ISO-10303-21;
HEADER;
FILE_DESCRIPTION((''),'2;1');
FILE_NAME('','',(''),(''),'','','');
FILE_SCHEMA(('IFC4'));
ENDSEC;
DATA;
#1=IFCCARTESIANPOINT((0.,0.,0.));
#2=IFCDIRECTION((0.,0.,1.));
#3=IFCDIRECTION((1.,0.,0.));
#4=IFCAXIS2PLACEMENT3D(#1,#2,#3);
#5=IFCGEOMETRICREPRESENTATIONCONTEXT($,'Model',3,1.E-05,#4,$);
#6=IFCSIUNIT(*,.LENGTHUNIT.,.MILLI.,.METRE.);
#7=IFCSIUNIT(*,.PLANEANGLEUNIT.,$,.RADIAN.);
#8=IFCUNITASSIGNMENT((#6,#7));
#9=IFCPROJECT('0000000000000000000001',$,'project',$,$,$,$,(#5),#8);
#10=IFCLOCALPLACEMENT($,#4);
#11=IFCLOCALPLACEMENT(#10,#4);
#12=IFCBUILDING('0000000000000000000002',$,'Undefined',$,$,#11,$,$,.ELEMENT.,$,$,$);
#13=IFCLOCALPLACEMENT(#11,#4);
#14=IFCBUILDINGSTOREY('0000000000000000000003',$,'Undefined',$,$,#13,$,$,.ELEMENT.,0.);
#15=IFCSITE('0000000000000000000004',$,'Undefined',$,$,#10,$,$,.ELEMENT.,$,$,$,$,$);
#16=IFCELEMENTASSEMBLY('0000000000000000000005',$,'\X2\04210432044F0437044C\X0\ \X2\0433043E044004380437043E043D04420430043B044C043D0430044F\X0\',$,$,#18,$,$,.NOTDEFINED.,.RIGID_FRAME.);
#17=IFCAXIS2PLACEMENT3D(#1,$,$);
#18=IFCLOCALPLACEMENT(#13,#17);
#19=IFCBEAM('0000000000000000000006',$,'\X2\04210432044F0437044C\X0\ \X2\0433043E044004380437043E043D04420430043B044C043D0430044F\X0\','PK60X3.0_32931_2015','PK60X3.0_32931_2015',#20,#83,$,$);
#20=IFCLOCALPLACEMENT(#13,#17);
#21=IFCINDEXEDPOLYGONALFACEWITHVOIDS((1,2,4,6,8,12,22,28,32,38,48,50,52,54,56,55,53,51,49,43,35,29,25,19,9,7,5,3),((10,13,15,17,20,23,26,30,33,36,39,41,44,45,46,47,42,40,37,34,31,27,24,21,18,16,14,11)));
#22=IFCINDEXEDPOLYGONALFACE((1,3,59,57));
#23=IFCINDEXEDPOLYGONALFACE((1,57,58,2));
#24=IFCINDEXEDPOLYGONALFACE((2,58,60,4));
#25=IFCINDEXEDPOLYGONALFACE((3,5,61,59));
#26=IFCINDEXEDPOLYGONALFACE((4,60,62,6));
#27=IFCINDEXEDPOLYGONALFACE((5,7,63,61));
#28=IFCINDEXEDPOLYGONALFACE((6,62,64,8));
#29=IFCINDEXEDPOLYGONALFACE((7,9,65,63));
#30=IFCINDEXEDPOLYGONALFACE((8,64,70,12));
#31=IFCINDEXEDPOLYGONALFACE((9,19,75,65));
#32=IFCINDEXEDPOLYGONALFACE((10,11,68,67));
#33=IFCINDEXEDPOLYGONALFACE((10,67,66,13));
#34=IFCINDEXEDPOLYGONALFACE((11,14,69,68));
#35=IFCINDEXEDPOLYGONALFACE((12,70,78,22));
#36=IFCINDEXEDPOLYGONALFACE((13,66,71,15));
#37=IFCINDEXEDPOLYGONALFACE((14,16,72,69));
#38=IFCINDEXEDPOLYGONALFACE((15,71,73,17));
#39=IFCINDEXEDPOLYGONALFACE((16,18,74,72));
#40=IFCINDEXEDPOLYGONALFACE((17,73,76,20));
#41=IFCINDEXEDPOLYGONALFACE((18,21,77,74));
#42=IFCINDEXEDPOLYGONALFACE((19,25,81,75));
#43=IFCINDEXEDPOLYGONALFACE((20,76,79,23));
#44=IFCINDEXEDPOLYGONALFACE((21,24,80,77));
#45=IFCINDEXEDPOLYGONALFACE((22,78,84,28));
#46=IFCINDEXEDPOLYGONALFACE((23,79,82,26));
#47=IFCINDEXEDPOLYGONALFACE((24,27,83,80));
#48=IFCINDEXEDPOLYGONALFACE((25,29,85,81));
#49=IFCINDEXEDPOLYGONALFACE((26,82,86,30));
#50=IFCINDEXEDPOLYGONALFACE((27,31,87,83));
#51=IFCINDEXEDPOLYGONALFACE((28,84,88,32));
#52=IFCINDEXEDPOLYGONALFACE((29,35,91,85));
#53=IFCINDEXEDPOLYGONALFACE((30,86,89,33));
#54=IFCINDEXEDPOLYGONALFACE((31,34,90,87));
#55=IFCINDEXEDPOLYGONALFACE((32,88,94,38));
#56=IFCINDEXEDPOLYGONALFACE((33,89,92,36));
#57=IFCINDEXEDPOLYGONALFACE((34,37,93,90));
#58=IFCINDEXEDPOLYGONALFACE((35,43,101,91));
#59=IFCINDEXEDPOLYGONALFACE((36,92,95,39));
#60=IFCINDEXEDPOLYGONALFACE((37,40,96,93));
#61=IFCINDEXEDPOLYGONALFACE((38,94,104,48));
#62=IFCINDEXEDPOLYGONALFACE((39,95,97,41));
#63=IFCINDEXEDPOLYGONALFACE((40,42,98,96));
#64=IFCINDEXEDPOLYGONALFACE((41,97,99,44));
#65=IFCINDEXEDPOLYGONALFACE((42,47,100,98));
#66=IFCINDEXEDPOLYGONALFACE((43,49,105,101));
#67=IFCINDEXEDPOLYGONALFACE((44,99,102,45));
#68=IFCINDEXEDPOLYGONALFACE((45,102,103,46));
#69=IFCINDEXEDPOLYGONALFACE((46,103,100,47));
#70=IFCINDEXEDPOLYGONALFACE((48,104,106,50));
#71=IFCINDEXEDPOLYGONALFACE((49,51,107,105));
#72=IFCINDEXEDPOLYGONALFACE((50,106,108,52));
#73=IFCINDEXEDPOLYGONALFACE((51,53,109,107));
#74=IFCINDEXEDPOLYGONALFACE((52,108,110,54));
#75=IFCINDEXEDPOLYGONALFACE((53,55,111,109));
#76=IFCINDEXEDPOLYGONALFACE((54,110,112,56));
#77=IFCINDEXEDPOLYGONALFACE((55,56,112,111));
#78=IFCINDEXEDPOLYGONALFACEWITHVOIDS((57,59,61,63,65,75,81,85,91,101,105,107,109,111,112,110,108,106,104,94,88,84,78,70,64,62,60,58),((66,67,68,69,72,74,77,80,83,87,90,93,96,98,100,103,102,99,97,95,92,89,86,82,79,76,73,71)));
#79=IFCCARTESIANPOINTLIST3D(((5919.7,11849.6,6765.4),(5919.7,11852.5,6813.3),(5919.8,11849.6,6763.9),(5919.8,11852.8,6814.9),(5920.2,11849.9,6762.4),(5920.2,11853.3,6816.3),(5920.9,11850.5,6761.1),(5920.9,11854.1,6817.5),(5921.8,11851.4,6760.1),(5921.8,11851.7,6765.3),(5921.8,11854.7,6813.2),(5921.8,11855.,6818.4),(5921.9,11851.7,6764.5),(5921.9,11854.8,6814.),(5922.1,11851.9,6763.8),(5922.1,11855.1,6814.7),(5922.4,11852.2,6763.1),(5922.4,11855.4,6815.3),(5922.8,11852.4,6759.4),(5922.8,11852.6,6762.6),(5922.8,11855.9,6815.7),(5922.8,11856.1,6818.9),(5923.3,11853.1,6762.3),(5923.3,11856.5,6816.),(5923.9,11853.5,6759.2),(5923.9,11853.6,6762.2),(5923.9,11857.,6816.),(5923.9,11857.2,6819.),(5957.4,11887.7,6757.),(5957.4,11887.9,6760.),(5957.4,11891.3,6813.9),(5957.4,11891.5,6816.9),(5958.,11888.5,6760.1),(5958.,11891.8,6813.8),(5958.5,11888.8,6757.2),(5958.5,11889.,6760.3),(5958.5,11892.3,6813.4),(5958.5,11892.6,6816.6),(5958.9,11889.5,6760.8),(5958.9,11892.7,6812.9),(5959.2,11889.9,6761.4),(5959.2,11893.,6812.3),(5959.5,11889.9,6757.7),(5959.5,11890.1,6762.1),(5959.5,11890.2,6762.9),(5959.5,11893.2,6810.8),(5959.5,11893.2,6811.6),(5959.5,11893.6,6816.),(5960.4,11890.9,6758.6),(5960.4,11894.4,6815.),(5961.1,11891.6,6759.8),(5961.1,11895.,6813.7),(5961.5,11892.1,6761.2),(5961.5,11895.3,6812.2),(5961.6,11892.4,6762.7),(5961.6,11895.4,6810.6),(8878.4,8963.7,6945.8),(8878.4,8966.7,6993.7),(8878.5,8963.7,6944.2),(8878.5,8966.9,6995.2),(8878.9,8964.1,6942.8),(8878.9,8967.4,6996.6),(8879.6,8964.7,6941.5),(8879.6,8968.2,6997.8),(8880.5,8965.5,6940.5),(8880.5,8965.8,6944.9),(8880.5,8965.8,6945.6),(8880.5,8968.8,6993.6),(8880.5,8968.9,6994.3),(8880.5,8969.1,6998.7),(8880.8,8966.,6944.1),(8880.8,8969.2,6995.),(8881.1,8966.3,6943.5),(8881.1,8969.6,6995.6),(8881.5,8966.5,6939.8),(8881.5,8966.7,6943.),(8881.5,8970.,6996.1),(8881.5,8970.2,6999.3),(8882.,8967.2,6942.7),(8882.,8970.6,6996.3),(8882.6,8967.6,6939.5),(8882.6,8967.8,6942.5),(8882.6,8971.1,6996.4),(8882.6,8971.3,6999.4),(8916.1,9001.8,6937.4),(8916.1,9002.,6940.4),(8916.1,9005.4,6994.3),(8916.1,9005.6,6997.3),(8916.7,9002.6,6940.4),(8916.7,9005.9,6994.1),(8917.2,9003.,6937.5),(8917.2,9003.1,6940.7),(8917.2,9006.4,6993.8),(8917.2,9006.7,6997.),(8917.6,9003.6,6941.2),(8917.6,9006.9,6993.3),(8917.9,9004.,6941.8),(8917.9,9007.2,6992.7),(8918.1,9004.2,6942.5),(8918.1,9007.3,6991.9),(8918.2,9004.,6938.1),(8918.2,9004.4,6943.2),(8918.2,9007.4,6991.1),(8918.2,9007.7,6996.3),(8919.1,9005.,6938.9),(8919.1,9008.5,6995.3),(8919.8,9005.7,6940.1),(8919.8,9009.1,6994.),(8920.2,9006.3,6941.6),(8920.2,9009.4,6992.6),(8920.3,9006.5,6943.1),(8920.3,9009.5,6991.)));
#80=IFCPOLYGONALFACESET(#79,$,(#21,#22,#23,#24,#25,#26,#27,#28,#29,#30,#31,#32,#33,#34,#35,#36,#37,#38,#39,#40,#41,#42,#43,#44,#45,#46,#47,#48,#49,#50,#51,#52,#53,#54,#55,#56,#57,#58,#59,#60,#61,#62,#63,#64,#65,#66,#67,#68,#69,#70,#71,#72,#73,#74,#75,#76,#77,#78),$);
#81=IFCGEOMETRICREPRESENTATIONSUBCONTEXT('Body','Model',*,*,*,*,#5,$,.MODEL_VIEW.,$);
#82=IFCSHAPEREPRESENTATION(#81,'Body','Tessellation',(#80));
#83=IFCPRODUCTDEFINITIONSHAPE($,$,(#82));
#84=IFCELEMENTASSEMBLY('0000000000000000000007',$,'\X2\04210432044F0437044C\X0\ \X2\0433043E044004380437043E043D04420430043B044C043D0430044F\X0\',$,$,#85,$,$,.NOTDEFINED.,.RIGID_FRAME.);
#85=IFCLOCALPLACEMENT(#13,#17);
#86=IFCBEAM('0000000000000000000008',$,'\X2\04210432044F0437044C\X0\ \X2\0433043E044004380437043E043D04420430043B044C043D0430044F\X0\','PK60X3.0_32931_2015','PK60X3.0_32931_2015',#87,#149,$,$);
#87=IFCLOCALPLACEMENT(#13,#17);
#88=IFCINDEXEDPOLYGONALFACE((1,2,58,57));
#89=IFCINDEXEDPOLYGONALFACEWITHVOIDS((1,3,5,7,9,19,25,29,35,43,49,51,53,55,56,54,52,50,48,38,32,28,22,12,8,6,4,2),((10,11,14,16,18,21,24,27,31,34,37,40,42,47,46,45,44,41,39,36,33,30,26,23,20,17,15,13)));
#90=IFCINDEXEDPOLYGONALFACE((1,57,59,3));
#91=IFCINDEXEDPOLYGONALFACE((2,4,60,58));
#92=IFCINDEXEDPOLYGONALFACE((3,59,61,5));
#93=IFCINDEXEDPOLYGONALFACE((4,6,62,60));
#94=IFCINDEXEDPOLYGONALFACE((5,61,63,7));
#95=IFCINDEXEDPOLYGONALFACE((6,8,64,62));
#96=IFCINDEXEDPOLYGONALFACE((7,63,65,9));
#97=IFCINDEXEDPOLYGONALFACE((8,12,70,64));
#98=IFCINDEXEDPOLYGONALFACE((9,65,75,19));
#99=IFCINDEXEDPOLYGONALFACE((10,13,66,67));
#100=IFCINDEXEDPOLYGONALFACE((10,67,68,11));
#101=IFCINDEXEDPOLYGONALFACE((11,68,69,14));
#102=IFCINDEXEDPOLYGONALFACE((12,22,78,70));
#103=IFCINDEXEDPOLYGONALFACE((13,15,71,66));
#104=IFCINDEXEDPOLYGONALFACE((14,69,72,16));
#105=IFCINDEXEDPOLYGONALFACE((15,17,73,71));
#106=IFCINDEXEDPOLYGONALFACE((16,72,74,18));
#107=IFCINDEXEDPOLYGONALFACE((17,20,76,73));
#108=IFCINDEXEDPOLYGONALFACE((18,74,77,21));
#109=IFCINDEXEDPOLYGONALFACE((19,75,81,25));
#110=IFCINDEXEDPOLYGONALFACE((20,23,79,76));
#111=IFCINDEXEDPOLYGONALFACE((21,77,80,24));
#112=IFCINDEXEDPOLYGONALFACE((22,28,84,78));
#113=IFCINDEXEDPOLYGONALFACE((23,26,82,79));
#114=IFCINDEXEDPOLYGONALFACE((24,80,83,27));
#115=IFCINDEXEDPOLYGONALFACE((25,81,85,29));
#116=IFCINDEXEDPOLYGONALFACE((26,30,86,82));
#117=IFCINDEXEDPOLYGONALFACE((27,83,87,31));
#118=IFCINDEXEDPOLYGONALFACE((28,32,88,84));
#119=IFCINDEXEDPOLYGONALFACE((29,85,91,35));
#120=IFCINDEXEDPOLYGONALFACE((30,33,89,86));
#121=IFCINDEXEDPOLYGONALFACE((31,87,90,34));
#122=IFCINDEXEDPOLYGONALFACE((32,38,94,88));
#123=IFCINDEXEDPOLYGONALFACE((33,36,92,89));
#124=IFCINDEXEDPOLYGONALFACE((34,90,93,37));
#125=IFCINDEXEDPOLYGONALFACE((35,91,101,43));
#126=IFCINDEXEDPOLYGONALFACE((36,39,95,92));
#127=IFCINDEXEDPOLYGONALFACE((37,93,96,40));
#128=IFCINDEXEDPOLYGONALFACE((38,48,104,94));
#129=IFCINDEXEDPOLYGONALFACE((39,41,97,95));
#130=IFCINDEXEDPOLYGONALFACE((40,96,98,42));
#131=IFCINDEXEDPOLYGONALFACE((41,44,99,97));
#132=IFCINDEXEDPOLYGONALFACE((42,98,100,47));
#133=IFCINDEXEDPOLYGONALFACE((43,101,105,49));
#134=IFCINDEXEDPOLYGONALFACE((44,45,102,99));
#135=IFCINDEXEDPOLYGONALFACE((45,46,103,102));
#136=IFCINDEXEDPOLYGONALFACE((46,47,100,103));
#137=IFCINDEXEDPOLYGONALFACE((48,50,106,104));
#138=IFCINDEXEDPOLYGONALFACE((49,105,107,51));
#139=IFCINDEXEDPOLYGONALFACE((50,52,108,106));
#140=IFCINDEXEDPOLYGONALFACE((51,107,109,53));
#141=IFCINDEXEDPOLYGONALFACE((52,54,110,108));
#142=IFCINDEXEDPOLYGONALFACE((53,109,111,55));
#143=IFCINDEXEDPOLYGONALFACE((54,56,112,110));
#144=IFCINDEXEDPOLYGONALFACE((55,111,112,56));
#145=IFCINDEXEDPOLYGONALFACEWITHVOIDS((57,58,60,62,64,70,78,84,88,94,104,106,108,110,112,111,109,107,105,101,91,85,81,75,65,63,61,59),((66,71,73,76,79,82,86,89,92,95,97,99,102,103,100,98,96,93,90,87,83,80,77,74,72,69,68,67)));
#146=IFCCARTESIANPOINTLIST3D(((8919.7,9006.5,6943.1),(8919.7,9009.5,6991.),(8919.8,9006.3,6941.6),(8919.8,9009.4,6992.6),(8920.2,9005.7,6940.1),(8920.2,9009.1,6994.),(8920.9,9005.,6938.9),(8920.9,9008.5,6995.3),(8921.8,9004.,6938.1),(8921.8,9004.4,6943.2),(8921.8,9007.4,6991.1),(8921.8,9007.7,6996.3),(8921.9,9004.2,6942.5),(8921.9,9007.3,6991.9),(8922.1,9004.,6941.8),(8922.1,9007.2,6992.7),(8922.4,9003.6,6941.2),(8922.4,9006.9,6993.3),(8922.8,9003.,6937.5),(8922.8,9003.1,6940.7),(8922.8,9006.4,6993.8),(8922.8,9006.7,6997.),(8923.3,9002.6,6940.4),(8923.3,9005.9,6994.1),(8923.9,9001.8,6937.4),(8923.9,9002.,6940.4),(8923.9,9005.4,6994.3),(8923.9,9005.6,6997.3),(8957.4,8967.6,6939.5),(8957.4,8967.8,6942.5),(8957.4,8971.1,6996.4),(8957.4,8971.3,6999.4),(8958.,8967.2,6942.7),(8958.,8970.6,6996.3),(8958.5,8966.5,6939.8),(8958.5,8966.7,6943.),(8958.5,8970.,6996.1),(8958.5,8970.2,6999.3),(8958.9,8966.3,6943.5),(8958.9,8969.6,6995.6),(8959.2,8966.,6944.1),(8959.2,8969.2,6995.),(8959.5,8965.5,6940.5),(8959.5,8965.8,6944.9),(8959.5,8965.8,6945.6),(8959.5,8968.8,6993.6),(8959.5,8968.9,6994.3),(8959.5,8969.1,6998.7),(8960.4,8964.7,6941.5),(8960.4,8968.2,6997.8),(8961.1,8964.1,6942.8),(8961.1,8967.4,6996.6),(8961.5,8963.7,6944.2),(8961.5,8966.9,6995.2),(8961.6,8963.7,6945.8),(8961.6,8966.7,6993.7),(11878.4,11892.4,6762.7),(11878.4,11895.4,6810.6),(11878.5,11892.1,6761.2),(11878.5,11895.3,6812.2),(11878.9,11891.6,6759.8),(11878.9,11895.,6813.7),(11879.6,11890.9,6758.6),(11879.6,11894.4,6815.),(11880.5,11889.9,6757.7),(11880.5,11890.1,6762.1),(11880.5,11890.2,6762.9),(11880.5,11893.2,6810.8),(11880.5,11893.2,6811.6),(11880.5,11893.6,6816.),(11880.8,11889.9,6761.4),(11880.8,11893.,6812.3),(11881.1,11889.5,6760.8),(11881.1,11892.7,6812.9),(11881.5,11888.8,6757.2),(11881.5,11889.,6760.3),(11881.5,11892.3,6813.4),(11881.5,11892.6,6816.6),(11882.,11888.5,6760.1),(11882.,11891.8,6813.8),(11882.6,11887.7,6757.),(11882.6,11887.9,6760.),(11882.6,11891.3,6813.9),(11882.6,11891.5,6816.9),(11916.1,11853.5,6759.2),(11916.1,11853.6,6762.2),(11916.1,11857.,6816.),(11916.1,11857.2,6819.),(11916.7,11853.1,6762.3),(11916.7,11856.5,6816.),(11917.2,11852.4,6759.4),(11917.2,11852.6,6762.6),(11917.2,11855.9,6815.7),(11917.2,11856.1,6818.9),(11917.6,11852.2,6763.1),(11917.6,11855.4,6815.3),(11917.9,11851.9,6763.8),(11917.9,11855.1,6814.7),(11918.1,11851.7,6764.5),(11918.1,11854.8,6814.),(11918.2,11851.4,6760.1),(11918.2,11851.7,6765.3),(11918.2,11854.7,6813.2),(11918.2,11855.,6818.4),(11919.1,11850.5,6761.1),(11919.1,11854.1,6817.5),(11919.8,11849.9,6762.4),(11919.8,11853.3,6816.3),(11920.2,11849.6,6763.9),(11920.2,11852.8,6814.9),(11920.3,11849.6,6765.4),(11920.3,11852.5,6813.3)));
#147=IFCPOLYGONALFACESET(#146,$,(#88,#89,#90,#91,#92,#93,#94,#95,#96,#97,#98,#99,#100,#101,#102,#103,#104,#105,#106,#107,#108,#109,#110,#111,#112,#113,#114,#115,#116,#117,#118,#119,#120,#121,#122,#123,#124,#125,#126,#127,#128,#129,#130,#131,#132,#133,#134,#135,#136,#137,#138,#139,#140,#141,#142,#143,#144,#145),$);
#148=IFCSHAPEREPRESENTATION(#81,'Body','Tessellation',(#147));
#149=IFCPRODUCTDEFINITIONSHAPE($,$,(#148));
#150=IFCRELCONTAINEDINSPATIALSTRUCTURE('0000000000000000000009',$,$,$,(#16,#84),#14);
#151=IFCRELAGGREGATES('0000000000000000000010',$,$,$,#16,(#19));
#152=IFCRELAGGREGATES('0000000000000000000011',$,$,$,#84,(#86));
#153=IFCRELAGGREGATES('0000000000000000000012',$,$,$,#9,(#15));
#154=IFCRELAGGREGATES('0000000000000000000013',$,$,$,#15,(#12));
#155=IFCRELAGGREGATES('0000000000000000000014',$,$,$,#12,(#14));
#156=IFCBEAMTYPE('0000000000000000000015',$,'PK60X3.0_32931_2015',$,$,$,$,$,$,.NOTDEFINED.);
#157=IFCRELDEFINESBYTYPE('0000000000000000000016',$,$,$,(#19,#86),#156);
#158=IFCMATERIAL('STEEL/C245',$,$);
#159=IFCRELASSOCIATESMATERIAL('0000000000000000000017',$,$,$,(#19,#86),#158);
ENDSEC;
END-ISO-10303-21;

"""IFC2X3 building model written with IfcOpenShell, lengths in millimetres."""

from ifc_helpers import new_model, si_unit, frame, origin_with_axes, origin_2d_with_axis, place, context, subcontext, project, spatial, hollow_rectangle, extrude, material, type_object, element, aggregate, save


model = new_model("IFC2X3")

# Units and contexts
model_context = context("Model", 3, precision=1e-05, world=origin_with_axes())
body_context = subcontext(model_context, "Body", "Model", "MODEL_VIEW")
ifc_project = project(units=[si_unit("LENGTHUNIT", "METRE", prefix="MILLI"), si_unit("PLANEANGLEUNIT", "RADIAN")], contexts=[model_context])

# Site, building, storey
site_placement = place(None, origin_with_axes())
site = spatial("IfcSite", under=ifc_project, at=site_placement, Name="Undefined", CompositionType="ELEMENT")
building_placement = place(site_placement, origin_with_axes())
building = spatial("IfcBuilding", under=site, at=building_placement, Name="Undefined", CompositionType="ELEMENT")
storey_placement = place(building_placement, origin_with_axes())
storey = spatial("IfcBuildingStorey", under=building, at=storey_placement, Name="Undefined", CompositionType="ELEMENT", Elevation=0.0)

# Shared definitions
ifc_material = material(Name="STEEL/C245")

# Element assemblies, beams
assembly_1_placement = place(storey_placement, origin_with_axes())
assembly_1 = element("IfcElementAssembly", 1, at=assembly_1_placement, inside=storey, Name="Связь горизонтальная", AssemblyPlace="NOTDEFINED", PredefinedType="RIGID_FRAME")
beam_type_1 = type_object("IfcBeamType", Name="PK60X3.0_32931_2015", PredefinedType="NOTDEFINED")
beam_1_placement = place(assembly_1_placement, frame((5940.7, 11872.5, 6788.0), z_axis=(0.0, 0.062378, 0.998053), x_axis=(0.715179, -0.69758, 0.043599)))
beam_1 = element("IfcBeam", 2, at=beam_1_placement, type_object=beam_type_1, material=ifc_material, Name="Связь горизонтальная", Description="PK60X3.0_32931_2015", ObjectType="PK60X3.0_32931_2015", context=body_context, shape_type="SweptSolid", body=[
    extrude(hollow_rectangle(XDim=60.0, YDim=60.0, WallThickness=3.0, InnerFilletRadius=3.0, OuterFilletRadius=6.0, at=origin_2d_with_axis()), frame((4137.0, 0.0, 0.0), z_axis=(-1.0, 0.0, 0.0), x_axis=(0.0, -1.0, 0.0)), (0.0, 0.0, 1.0), 4137.0),
])
aggregate(assembly_1, [beam_1])
assembly_2_placement = place(storey_placement, origin_with_axes())
assembly_2 = element("IfcElementAssembly", 3, at=assembly_2_placement, inside=storey, Name="Связь горизонтальная", AssemblyPlace="NOTDEFINED", PredefinedType="RIGID_FRAME")
beam_2_placement = place(assembly_2_placement, frame((11899.3, 11872.5, 6788.0), z_axis=(0.0, 0.062378, 0.998053), x_axis=(-0.715179, -0.69758, 0.043599)))
beam_2 = element("IfcBeam", 4, at=beam_2_placement, type_object=beam_type_1, material=ifc_material, Name="Связь горизонтальная", Description="PK60X3.0_32931_2015", ObjectType="PK60X3.0_32931_2015", context=body_context, shape_type="SweptSolid", body=[
    extrude(hollow_rectangle(XDim=60.0, YDim=60.0, WallThickness=3.0, InnerFilletRadius=3.0, OuterFilletRadius=6.0, at=origin_2d_with_axis()), frame((4137.0, 0.0, 0.0), z_axis=(-1.0, 0.0, 0.0), x_axis=(0.0, -1.0, 0.0)), (0.0, 0.0, 1.0), 4137.0),
])
aggregate(assembly_2, [beam_2])

save(model, "model.ifc")
